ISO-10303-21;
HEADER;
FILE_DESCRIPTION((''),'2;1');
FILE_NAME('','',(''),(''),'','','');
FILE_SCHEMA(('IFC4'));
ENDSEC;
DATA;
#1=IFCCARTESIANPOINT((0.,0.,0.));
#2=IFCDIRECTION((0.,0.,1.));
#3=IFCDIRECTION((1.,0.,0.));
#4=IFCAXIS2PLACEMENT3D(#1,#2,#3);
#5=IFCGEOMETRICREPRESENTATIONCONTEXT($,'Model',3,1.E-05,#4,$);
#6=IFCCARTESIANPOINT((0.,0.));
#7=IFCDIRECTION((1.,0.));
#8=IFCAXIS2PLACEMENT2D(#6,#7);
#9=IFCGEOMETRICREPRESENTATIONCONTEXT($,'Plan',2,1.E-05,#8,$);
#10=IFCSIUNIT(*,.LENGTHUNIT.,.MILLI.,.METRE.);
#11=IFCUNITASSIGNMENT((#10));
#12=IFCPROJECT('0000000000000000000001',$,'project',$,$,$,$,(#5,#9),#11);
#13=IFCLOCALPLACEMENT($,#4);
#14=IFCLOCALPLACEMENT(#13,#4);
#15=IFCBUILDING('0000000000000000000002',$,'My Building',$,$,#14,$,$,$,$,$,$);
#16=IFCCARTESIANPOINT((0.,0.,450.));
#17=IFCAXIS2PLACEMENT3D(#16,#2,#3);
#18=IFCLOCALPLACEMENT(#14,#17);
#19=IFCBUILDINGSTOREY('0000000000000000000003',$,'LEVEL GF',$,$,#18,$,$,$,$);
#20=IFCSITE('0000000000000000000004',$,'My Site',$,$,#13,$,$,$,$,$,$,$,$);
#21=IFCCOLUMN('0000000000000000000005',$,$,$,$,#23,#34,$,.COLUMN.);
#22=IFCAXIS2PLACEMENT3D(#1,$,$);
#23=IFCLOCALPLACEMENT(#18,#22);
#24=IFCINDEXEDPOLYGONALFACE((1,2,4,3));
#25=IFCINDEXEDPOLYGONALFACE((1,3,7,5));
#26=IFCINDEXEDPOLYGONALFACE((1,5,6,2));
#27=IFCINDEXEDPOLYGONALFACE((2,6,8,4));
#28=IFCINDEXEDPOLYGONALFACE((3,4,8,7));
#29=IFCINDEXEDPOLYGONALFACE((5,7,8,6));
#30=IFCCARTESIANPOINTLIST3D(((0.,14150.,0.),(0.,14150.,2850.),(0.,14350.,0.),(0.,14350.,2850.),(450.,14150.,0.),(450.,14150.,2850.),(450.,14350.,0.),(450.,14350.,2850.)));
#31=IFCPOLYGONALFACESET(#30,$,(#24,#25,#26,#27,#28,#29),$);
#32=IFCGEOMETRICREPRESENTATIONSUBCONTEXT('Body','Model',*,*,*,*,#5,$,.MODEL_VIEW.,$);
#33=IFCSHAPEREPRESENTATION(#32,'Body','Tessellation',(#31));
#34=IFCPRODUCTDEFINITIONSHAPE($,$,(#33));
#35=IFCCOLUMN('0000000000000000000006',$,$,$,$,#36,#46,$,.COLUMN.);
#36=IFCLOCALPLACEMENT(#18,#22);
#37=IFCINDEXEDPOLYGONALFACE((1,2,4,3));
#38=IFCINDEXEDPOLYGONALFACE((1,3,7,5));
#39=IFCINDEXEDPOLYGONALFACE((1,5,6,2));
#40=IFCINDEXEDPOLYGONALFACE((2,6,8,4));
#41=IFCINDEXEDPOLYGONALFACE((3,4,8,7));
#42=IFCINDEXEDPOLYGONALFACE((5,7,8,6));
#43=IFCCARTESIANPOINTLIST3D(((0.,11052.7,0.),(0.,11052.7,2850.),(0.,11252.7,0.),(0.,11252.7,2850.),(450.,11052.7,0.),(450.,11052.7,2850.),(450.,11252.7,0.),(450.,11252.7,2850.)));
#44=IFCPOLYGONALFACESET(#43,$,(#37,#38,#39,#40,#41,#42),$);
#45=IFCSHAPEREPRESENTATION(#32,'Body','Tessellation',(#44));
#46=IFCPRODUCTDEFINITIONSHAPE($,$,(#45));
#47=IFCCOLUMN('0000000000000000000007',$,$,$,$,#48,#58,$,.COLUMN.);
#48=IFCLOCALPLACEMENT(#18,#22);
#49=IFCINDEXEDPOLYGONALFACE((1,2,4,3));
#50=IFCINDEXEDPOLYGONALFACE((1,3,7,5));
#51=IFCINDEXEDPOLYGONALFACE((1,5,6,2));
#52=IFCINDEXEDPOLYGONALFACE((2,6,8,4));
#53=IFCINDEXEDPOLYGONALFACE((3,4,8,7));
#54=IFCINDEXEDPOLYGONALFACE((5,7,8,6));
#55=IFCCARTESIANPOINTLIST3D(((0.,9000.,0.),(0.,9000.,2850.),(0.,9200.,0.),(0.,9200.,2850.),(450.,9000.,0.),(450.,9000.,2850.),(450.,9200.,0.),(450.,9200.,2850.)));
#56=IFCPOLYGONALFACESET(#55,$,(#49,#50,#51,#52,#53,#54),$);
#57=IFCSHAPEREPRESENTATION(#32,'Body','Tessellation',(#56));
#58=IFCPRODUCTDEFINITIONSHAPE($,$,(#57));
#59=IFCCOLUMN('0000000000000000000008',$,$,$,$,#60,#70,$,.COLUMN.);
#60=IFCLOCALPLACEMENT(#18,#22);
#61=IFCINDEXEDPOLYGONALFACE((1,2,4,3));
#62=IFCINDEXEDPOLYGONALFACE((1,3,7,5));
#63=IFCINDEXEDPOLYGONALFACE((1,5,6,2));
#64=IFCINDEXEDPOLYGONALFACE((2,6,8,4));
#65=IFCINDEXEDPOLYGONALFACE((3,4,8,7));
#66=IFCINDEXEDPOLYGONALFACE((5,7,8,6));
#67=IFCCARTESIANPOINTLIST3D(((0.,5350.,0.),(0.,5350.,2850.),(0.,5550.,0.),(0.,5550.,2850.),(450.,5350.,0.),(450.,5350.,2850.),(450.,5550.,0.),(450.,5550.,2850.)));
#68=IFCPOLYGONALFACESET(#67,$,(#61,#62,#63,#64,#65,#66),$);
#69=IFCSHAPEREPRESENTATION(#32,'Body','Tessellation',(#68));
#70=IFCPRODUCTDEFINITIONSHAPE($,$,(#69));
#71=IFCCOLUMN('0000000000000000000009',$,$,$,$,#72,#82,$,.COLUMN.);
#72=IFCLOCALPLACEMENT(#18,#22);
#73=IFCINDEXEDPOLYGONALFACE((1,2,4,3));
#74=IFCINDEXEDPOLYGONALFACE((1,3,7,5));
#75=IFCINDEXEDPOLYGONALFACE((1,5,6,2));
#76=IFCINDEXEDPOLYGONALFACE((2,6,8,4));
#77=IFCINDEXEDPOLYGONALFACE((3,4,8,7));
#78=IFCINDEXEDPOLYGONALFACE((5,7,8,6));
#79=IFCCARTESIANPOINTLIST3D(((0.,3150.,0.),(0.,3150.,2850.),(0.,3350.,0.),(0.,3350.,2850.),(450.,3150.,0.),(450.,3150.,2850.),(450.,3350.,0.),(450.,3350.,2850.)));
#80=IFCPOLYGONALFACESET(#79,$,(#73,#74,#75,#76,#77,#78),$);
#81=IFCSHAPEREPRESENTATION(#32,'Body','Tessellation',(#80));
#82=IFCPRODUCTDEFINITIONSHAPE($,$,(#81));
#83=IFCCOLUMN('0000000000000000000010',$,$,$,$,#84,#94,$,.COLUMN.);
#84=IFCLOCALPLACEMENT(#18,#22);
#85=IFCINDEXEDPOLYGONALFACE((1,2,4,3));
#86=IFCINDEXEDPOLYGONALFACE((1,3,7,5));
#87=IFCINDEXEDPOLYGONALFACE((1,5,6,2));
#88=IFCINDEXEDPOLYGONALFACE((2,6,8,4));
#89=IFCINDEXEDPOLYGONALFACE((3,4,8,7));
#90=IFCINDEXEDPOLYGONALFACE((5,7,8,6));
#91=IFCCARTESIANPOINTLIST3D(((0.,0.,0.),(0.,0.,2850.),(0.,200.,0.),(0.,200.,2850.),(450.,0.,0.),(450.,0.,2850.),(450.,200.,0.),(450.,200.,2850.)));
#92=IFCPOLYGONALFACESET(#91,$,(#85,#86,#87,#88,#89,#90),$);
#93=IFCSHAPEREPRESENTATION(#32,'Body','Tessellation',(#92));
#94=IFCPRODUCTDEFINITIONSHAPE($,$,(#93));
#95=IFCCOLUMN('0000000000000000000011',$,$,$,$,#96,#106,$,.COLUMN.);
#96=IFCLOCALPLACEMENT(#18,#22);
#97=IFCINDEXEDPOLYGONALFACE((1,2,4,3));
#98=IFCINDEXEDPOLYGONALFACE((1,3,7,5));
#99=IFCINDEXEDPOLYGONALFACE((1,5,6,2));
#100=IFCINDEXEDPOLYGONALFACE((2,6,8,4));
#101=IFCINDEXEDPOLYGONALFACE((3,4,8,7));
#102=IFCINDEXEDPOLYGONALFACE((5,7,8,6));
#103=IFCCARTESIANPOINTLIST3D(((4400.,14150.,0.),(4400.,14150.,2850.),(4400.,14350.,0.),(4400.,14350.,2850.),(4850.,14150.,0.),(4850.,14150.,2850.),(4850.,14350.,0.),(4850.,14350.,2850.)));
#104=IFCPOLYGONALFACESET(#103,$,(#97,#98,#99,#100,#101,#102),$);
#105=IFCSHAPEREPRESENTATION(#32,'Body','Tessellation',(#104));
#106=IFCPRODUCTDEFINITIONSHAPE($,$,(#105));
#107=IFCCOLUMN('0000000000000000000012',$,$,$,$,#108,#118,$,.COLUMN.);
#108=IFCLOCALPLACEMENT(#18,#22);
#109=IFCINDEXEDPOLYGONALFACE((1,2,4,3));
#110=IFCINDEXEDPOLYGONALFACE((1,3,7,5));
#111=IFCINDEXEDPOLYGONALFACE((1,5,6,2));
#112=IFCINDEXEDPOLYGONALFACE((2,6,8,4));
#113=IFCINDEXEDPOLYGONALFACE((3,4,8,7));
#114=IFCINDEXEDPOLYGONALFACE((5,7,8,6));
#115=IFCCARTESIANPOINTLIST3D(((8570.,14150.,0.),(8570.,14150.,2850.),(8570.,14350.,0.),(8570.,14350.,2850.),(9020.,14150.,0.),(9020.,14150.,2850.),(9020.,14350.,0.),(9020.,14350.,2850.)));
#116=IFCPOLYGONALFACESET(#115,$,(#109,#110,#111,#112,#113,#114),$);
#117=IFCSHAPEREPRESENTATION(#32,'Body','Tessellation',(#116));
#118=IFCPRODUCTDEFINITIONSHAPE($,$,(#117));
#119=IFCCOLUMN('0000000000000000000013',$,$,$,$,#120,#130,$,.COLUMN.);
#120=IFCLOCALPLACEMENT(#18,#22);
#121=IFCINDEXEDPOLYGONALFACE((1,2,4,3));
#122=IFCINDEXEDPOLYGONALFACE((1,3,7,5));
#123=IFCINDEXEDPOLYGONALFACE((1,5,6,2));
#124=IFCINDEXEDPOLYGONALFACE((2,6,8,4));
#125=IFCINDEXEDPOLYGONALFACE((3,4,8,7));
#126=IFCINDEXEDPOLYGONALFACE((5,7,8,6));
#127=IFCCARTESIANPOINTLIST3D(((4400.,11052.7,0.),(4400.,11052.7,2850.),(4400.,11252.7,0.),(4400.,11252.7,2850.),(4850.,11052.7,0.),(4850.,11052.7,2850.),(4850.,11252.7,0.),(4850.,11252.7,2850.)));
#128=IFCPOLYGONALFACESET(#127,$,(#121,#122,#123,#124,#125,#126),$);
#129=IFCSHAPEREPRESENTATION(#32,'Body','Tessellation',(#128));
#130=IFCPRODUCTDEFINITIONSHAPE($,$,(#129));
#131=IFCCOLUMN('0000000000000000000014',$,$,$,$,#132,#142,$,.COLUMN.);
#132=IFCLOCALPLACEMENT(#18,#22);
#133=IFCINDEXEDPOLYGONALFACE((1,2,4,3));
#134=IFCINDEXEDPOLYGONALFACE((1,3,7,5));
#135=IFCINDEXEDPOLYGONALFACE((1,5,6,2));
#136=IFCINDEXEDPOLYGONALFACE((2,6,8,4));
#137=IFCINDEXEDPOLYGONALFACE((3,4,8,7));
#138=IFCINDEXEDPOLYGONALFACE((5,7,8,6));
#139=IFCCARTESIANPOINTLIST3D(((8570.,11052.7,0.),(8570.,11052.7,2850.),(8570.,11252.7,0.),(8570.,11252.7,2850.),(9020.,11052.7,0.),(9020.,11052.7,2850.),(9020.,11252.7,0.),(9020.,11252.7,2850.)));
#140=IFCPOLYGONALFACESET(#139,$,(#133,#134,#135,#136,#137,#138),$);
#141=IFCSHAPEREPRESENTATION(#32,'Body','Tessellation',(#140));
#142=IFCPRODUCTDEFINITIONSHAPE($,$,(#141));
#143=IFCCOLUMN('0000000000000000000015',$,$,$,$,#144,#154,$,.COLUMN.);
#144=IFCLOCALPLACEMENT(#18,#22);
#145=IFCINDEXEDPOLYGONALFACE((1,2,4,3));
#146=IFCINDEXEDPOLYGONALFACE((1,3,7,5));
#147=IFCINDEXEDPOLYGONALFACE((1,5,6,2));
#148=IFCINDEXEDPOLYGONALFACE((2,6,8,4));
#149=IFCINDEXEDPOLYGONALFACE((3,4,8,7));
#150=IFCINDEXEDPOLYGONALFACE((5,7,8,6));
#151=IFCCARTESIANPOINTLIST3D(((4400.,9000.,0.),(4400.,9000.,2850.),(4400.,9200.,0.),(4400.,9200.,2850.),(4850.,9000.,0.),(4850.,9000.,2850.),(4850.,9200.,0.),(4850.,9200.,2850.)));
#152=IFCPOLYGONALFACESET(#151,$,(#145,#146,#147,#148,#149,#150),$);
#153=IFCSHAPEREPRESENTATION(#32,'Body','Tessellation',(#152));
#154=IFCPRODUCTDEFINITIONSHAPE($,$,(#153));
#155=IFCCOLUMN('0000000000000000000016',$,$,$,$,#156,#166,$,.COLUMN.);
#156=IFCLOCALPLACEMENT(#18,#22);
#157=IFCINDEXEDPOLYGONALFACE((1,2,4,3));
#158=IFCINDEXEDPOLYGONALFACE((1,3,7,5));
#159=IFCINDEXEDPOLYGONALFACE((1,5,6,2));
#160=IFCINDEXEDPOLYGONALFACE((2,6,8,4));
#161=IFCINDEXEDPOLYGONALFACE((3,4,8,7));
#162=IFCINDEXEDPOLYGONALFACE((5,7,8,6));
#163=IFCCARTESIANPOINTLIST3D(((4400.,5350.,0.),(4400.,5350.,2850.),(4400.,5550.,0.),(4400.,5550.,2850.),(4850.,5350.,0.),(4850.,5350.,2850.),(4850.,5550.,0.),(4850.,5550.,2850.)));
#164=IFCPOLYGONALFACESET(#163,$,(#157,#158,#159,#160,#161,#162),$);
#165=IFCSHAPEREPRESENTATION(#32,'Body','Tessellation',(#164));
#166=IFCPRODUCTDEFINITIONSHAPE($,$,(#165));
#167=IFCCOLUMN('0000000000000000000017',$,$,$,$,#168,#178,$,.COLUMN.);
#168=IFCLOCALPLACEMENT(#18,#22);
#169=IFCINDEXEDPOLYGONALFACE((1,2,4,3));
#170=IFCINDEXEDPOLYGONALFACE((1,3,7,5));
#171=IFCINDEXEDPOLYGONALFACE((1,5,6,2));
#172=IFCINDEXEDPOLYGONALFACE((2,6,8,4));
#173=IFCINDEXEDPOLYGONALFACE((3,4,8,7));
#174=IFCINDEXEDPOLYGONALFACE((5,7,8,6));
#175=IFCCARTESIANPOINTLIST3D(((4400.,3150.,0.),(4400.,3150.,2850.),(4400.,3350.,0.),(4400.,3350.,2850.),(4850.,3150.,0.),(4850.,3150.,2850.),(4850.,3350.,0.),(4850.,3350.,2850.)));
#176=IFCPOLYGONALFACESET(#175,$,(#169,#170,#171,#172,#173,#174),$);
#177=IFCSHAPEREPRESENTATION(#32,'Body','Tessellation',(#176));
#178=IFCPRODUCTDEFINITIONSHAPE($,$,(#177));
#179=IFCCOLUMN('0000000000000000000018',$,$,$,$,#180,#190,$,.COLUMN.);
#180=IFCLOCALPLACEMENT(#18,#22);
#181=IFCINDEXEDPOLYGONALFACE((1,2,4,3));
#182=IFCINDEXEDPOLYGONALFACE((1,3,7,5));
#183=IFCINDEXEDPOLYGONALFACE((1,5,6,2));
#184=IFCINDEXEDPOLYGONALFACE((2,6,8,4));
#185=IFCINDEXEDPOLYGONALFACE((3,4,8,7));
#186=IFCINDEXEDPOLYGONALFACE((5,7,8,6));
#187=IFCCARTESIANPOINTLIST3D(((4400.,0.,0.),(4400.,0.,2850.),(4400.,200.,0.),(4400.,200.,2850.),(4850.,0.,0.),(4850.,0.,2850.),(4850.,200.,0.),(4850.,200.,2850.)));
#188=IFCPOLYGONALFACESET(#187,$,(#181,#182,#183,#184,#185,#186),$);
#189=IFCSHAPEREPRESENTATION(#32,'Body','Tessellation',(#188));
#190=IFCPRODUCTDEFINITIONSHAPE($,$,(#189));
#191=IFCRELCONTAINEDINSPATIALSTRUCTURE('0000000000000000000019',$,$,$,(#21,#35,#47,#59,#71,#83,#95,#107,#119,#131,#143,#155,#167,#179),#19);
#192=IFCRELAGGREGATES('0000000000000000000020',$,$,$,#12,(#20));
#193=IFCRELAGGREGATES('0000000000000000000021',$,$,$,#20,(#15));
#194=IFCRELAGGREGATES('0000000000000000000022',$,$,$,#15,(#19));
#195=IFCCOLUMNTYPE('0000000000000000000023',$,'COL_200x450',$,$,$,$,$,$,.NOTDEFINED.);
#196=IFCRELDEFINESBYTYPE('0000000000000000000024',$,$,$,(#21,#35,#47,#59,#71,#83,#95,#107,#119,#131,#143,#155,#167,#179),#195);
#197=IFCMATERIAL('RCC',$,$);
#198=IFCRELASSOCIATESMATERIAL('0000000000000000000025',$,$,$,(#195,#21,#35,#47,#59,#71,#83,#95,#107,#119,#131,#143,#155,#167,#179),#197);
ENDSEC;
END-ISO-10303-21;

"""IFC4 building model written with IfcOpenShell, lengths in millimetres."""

from ifc_helpers import new_model, si_unit, frame, origin_with_axes, origin_2d_with_axis, place, context, subcontext, project, spatial, rectangle, extrude, material, material_profile, profile_set, profile_usage, type_object, element, save


model = new_model("IFC4")

# Units and contexts
model_context = context("Model", 3, precision=1e-05, world=origin_with_axes())
plan_context = context("Plan", 2, precision=1e-05, world=origin_2d_with_axis())
body_context = subcontext(model_context, "Body", "Model", "MODEL_VIEW")
ifc_project = project(units=[si_unit("LENGTHUNIT", "METRE", prefix="MILLI")], contexts=[model_context, plan_context])

# Site, building, storey
site_placement = place(None, origin_with_axes())
site = spatial("IfcSite", under=ifc_project, at=site_placement, Name="My Site")
building_placement = place(site_placement, origin_with_axes())
building = spatial("IfcBuilding", under=site, at=building_placement, Name="My Building")
storey_placement = place(building_placement, frame((0.0, 0.0, 450.0), z_axis=(0.0, 0.0, 1.0), x_axis=(1.0, 0.0, 0.0)))
storey = spatial("IfcBuildingStorey", under=building, at=storey_placement, Name="LEVEL GF")

# Columns
ifc_material_1 = material(Name="RCC")
ifc_material_profile = material_profile(ifc_material_1, rectangle(XDim=200.0, YDim=450.0))
ifc_profile_set = profile_set([ifc_material_profile], Name="COL_200x450")
ifc_profile_usage_1 = profile_usage(ifc_profile_set)
column_type = type_object("IfcColumnType", Name="COL_200x450", PredefinedType="NOTDEFINED", material=ifc_profile_set)
column_1_placement = place(storey_placement, frame((225.0, 14250.0, 0.0), z_axis=(0.0, 0.0, 1.0), x_axis=(0.0, -1.0, 0.0)))
element("IfcColumn", 1, at=column_1_placement, inside=storey, type_object=column_type, material=ifc_profile_usage_1, PredefinedType="COLUMN", context=body_context, shape_type="SweptSolid", body=[
    extrude(rectangle(XDim=200.0, YDim=450.0), origin_with_axes(), (0.0, 0.0, 1.0), 2850.0),
])
ifc_profile_usage_2 = profile_usage(ifc_profile_set)
column_2_placement = place(storey_placement, frame((225.0, 11152.7, 0.0), z_axis=(0.0, 0.0, 1.0), x_axis=(0.0, -1.0, 0.0)))
element("IfcColumn", 2, at=column_2_placement, inside=storey, type_object=column_type, material=ifc_profile_usage_2, PredefinedType="COLUMN", context=body_context, shape_type="SweptSolid", body=[
    extrude(rectangle(XDim=200.0, YDim=450.0), origin_with_axes(), (0.0, 0.0, 1.0), 2850.0),
])
ifc_profile_usage_3 = profile_usage(ifc_profile_set)
column_3_placement = place(storey_placement, frame((225.0, 9100.0, 0.0), z_axis=(0.0, 0.0, 1.0), x_axis=(0.0, -1.0, 0.0)))
element("IfcColumn", 3, at=column_3_placement, inside=storey, type_object=column_type, material=ifc_profile_usage_3, PredefinedType="COLUMN", context=body_context, shape_type="SweptSolid", body=[
    extrude(rectangle(XDim=200.0, YDim=450.0), origin_with_axes(), (0.0, 0.0, 1.0), 2850.0),
])
ifc_profile_usage_4 = profile_usage(ifc_profile_set)
column_4_placement = place(storey_placement, frame((225.0, 5450.0, 0.0), z_axis=(0.0, 0.0, 1.0), x_axis=(0.0, -1.0, 0.0)))
element("IfcColumn", 4, at=column_4_placement, inside=storey, type_object=column_type, material=ifc_profile_usage_4, PredefinedType="COLUMN", context=body_context, shape_type="SweptSolid", body=[
    extrude(rectangle(XDim=200.0, YDim=450.0), origin_with_axes(), (0.0, 0.0, 1.0), 2850.0),
])
ifc_profile_usage_5 = profile_usage(ifc_profile_set)
column_5_placement = place(storey_placement, frame((225.0, 3250.0, 0.0), z_axis=(0.0, 0.0, 1.0), x_axis=(0.0, -1.0, 0.0)))
element("IfcColumn", 5, at=column_5_placement, inside=storey, type_object=column_type, material=ifc_profile_usage_5, PredefinedType="COLUMN", context=body_context, shape_type="SweptSolid", body=[
    extrude(rectangle(XDim=200.0, YDim=450.0), origin_with_axes(), (0.0, 0.0, 1.0), 2850.0),
])
ifc_profile_usage_6 = profile_usage(ifc_profile_set)
column_6_placement = place(storey_placement, frame((225.0, 100.0, 0.0), z_axis=(0.0, 0.0, 1.0), x_axis=(0.0, -1.0, 0.0)))
element("IfcColumn", 6, at=column_6_placement, inside=storey, type_object=column_type, material=ifc_profile_usage_6, PredefinedType="COLUMN", context=body_context, shape_type="SweptSolid", body=[
    extrude(rectangle(XDim=200.0, YDim=450.0), origin_with_axes(), (0.0, 0.0, 1.0), 2850.0),
])
ifc_profile_usage_7 = profile_usage(ifc_profile_set)
column_7_placement = place(storey_placement, frame((4625.0, 14250.0, 0.0), z_axis=(0.0, 0.0, 1.0), x_axis=(0.0, -1.0, 0.0)))
element("IfcColumn", 7, at=column_7_placement, inside=storey, type_object=column_type, material=ifc_profile_usage_7, PredefinedType="COLUMN", context=body_context, shape_type="SweptSolid", body=[
    extrude(rectangle(XDim=200.0, YDim=450.0), origin_with_axes(), (0.0, 0.0, 1.0), 2850.0),
])
ifc_profile_usage_8 = profile_usage(ifc_profile_set)
column_8_placement = place(storey_placement, frame((8795.0, 14250.0, 0.0), z_axis=(0.0, 0.0, 1.0), x_axis=(0.0, -1.0, 0.0)))
element("IfcColumn", 8, at=column_8_placement, inside=storey, type_object=column_type, material=ifc_profile_usage_8, PredefinedType="COLUMN", context=body_context, shape_type="SweptSolid", body=[
    extrude(rectangle(XDim=200.0, YDim=450.0), origin_with_axes(), (0.0, 0.0, 1.0), 2850.0),
])
ifc_profile_usage_9 = profile_usage(ifc_profile_set)
column_9_placement = place(storey_placement, frame((4625.0, 11152.7, 0.0), z_axis=(0.0, 0.0, 1.0), x_axis=(0.0, -1.0, 0.0)))
element("IfcColumn", 9, at=column_9_placement, inside=storey, type_object=column_type, material=ifc_profile_usage_9, PredefinedType="COLUMN", context=body_context, shape_type="SweptSolid", body=[
    extrude(rectangle(XDim=200.0, YDim=450.0), origin_with_axes(), (0.0, 0.0, 1.0), 2850.0),
])
ifc_profile_usage_10 = profile_usage(ifc_profile_set)
column_10_placement = place(storey_placement, frame((8795.0, 11152.7, 0.0), z_axis=(0.0, 0.0, 1.0), x_axis=(0.0, -1.0, 0.0)))
element("IfcColumn", 10, at=column_10_placement, inside=storey, type_object=column_type, material=ifc_profile_usage_10, PredefinedType="COLUMN", context=body_context, shape_type="SweptSolid", body=[
    extrude(rectangle(XDim=200.0, YDim=450.0), origin_with_axes(), (0.0, 0.0, 1.0), 2850.0),
])
ifc_profile_usage_11 = profile_usage(ifc_profile_set)
column_11_placement = place(storey_placement, frame((4625.0, 9100.0, 0.0), z_axis=(0.0, 0.0, 1.0), x_axis=(0.0, -1.0, 0.0)))
element("IfcColumn", 11, at=column_11_placement, inside=storey, type_object=column_type, material=ifc_profile_usage_11, PredefinedType="COLUMN", context=body_context, shape_type="SweptSolid", body=[
    extrude(rectangle(XDim=200.0, YDim=450.0), origin_with_axes(), (0.0, 0.0, 1.0), 2850.0),
])
ifc_profile_usage_12 = profile_usage(ifc_profile_set)
column_12_placement = place(storey_placement, frame((4625.0, 5450.0, 0.0), z_axis=(0.0, 0.0, 1.0), x_axis=(0.0, -1.0, 0.0)))
element("IfcColumn", 12, at=column_12_placement, inside=storey, type_object=column_type, material=ifc_profile_usage_12, PredefinedType="COLUMN", context=body_context, shape_type="SweptSolid", body=[
    extrude(rectangle(XDim=200.0, YDim=450.0), origin_with_axes(), (0.0, 0.0, 1.0), 2850.0),
])
ifc_profile_usage_13 = profile_usage(ifc_profile_set)
column_13_placement = place(storey_placement, frame((4625.0, 3250.0, 0.0), z_axis=(0.0, 0.0, 1.0), x_axis=(0.0, -1.0, 0.0)))
element("IfcColumn", 13, at=column_13_placement, inside=storey, type_object=column_type, material=ifc_profile_usage_13, PredefinedType="COLUMN", context=body_context, shape_type="SweptSolid", body=[
    extrude(rectangle(XDim=200.0, YDim=450.0), origin_with_axes(), (0.0, 0.0, 1.0), 2850.0),
])
ifc_profile_usage_14 = profile_usage(ifc_profile_set)
column_14_placement = place(storey_placement, frame((4625.0, 100.0, 0.0), z_axis=(0.0, 0.0, 1.0), x_axis=(0.0, -1.0, 0.0)))
element("IfcColumn", 14, at=column_14_placement, inside=storey, type_object=column_type, material=ifc_profile_usage_14, PredefinedType="COLUMN", context=body_context, shape_type="SweptSolid", body=[
    extrude(rectangle(XDim=200.0, YDim=450.0), origin_with_axes(), (0.0, 0.0, 1.0), 2850.0),
])

save(model, "model.ifc")
